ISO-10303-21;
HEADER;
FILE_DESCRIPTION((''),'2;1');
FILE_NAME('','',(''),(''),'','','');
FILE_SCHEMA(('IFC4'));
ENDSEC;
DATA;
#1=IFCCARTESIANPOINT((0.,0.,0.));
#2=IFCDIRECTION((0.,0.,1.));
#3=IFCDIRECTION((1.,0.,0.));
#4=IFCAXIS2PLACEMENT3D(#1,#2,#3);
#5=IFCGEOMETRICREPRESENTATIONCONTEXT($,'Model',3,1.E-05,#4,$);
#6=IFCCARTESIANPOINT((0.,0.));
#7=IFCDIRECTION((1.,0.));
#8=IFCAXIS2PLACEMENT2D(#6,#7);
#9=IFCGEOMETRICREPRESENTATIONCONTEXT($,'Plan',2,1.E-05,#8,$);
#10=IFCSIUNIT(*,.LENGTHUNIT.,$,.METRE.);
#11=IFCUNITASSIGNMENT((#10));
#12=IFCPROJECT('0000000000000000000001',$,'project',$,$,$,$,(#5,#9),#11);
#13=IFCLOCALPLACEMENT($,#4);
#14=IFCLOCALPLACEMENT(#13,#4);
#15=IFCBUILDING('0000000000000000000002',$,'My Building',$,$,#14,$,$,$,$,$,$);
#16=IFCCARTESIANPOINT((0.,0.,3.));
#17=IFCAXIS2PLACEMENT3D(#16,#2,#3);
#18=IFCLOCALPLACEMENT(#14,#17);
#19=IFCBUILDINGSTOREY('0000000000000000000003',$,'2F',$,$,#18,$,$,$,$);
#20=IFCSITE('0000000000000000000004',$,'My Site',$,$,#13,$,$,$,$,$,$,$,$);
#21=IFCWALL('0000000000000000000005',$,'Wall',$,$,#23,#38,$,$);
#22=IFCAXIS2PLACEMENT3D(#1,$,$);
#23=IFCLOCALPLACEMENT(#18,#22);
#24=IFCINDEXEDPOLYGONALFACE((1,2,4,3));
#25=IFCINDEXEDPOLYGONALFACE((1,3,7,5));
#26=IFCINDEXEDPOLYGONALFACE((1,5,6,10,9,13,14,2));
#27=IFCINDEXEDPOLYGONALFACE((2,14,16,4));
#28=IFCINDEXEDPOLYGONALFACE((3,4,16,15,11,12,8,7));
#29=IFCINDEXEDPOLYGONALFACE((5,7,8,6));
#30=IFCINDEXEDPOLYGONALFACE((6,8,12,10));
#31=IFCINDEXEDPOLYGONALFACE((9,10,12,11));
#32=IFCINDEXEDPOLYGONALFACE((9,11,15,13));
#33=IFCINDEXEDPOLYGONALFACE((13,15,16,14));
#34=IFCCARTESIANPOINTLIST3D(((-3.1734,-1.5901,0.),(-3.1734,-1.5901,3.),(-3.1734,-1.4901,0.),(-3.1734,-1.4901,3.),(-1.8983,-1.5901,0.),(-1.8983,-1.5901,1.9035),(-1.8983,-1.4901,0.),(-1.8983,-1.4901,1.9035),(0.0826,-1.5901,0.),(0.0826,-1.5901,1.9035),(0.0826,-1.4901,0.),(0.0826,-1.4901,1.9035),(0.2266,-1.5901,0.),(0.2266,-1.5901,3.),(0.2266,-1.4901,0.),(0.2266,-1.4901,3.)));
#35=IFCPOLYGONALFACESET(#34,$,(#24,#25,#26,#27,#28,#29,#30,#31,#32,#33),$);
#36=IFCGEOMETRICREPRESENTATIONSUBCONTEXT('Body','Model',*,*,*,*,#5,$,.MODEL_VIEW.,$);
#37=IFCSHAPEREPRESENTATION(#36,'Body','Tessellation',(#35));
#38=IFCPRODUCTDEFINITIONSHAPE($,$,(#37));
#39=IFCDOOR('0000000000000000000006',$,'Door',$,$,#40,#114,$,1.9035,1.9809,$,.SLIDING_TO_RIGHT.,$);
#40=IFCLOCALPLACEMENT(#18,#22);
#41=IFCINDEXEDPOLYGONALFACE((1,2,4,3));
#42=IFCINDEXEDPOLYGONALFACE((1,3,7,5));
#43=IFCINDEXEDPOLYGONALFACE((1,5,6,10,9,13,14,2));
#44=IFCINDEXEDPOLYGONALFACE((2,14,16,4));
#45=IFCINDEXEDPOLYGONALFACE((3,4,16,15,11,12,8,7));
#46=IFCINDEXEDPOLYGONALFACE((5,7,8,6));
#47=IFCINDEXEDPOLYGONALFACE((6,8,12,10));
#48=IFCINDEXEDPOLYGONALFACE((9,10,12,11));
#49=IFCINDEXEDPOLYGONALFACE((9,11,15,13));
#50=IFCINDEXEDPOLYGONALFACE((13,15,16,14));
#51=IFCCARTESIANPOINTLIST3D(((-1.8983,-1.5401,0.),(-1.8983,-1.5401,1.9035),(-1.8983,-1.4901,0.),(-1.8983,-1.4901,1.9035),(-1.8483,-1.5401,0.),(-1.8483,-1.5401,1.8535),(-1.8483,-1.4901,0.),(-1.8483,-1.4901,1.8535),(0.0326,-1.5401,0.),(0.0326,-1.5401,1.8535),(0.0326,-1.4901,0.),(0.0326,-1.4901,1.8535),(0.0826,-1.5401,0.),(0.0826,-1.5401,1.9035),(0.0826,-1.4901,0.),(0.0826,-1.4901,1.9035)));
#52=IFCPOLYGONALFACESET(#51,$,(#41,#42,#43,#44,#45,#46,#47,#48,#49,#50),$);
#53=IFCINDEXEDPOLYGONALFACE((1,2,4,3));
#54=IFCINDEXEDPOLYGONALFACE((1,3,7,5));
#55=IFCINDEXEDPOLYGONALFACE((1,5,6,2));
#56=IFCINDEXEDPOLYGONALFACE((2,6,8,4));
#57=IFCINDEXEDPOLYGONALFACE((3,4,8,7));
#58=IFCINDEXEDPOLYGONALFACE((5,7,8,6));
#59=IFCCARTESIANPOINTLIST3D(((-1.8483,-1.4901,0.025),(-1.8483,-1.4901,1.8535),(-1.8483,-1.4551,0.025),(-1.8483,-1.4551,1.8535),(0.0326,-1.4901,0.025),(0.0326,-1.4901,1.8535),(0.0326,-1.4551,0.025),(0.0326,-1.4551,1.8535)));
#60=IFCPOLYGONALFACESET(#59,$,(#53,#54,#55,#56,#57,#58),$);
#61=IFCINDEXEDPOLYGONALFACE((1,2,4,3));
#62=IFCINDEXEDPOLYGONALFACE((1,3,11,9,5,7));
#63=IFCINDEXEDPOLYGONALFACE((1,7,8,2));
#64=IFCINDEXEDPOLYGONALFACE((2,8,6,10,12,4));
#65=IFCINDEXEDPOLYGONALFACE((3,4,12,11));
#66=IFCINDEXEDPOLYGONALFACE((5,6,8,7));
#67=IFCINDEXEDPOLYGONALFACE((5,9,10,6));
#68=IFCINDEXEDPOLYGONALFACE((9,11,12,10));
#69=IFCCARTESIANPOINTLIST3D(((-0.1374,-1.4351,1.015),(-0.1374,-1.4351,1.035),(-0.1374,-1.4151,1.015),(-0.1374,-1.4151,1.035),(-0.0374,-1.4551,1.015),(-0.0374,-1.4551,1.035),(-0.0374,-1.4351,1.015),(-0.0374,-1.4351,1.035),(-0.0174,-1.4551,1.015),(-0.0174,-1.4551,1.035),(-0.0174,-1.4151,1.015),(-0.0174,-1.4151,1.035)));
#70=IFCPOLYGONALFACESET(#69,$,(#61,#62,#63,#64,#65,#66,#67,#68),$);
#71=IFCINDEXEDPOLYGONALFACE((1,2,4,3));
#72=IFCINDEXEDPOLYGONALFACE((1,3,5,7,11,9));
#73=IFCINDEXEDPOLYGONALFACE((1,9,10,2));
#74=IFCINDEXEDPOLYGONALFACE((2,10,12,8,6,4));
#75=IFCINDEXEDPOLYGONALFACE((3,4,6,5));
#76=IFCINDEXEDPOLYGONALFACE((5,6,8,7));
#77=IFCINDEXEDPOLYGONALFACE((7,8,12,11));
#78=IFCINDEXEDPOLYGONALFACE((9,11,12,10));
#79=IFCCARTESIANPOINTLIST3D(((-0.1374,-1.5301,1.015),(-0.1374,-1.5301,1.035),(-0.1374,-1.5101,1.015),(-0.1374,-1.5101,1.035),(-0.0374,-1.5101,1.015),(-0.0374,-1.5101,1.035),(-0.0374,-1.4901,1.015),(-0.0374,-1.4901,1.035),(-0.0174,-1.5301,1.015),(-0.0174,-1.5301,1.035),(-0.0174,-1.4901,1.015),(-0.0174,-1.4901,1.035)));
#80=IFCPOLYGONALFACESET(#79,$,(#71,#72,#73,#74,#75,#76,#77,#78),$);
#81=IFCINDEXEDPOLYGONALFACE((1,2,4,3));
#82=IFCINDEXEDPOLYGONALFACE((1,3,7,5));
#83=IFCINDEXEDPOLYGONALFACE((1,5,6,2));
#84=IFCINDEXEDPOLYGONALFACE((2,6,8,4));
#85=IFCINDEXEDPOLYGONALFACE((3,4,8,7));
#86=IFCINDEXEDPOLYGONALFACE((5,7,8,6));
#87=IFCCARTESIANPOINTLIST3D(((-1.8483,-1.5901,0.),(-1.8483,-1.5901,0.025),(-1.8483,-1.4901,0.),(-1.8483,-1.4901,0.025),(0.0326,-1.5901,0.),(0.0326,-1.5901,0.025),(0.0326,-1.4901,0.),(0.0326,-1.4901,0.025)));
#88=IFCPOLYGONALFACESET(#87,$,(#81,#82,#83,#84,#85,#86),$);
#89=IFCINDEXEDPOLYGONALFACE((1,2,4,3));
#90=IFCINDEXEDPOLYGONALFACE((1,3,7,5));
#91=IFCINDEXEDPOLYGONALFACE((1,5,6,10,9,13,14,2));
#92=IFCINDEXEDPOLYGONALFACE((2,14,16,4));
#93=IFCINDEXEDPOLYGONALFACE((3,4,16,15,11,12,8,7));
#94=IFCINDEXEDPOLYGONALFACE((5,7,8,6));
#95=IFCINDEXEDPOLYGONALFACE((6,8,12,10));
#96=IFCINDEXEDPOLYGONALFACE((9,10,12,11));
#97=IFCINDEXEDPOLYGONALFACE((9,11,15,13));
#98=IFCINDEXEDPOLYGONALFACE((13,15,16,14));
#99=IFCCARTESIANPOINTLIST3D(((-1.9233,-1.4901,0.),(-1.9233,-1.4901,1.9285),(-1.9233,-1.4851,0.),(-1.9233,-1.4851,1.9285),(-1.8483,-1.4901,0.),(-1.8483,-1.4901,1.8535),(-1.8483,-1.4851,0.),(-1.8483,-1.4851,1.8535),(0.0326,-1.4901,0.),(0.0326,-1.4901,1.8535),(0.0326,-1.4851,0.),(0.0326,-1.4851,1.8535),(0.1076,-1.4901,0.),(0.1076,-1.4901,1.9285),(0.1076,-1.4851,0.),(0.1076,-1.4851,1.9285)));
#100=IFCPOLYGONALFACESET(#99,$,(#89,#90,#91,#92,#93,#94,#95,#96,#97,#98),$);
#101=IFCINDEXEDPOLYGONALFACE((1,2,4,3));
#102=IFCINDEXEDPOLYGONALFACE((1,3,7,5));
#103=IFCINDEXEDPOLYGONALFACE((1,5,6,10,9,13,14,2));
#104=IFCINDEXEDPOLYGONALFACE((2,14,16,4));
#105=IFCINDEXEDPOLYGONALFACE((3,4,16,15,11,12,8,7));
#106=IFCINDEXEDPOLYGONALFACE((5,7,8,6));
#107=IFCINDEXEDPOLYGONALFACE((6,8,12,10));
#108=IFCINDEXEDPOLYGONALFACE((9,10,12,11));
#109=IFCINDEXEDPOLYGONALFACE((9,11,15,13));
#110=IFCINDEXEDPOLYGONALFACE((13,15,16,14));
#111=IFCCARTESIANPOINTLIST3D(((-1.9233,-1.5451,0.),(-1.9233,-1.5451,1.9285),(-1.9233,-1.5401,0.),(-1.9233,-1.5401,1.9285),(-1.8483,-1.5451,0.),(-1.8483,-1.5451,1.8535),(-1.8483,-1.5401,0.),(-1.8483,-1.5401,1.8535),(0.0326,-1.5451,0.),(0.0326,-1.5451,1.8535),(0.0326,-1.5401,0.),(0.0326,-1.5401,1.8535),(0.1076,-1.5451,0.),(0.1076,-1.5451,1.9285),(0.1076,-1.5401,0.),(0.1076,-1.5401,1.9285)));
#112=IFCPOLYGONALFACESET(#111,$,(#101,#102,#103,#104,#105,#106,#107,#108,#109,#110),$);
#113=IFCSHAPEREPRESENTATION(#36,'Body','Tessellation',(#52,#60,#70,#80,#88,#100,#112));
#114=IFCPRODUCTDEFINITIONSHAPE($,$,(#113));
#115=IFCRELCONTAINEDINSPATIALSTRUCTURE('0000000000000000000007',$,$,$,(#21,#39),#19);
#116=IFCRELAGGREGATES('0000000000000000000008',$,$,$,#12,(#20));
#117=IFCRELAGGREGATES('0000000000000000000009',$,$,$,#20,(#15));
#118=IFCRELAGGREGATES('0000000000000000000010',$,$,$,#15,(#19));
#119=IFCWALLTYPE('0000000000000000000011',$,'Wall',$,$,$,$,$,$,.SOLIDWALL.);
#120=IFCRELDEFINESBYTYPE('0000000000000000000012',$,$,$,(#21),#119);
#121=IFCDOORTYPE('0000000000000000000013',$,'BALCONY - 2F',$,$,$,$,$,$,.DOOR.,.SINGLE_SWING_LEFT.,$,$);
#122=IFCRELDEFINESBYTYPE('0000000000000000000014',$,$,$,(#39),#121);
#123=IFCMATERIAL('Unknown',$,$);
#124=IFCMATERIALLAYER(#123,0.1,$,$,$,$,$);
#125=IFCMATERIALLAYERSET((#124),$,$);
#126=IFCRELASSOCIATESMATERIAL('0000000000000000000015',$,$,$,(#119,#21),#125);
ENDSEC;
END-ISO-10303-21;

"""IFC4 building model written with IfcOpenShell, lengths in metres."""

from ifc_helpers import new_model, entity, si_unit, frame, origin_with_axes, origin_2d_with_axis, place, context, subcontext, project, spatial, line, indexed_curve, outline, extrude, shape, source, transform, mapped, material, layer, layer_set, layer_usage, type_object, type_shapes, element, fill, save


model = new_model("IFC4")

# Units and contexts
model_context = context("Model", 3, precision=1e-05, world=origin_with_axes())
plan_context = context("Plan", 2, precision=1e-05, world=origin_2d_with_axis())
body_context_1 = subcontext(model_context, "Body", "Model", "MODEL_VIEW")
body_context_2 = subcontext(plan_context, "Body", "Plan", "PLAN_VIEW")
ifc_project = project(units=[si_unit("LENGTHUNIT", "METRE")], contexts=[model_context, plan_context])

# Site, building, storey
site_placement = place(None, origin_with_axes())
site = spatial("IfcSite", under=ifc_project, at=site_placement, Name="My Site")
building_placement = place(site_placement, origin_with_axes())
building = spatial("IfcBuilding", under=site, at=building_placement, Name="My Building")
storey_placement = place(building_placement, frame((0.0, 0.0, 3.0), z_axis=(0.0, 0.0, 1.0), x_axis=(1.0, 0.0, 0.0)))
storey = spatial("IfcBuildingStorey", under=building, at=storey_placement, Name="2F")

# Shared definitions
ifc_material = material(Name="Unknown")

# Shared definitions
ifc_layer_1 = layer(ifc_material, 0.1)
ifc_layer_set_1 = layer_set([ifc_layer_1])
wall_type = type_object("IfcWallType", Name="Wall", PredefinedType="SOLIDWALL", material=ifc_layer_set_1)

# Wall, opening, door
ifc_layer_usage_1 = layer_usage(ifc_layer_set_1, "AXIS2", "POSITIVE", 0.0)
wall_1_placement = place(storey_placement, frame((-3.1734, -1.5901, 0.0), z_axis=(0.0, 0.0, 1.0), x_axis=(1.0, 0.0, 0.0)))
wall_1 = element("IfcWall", 1, at=wall_1_placement, inside=storey, type_object=wall_type, material=ifc_layer_usage_1, Name="Wall", context=body_context_1, shape_type="SweptSolid", body=[
    extrude(outline(indexed_curve([(0.0, 0.0), (0.0, 0.1), (3.4, 0.1), (3.4, 0.0)], segments=[line(1, 2, 3, 4, 1)])), origin_with_axes(), (0.0, 0.0, 1.0), 3.0),
])
shared_shape_1 = source(origin_with_axes(), body_context_1, "Body", "SweptSolid", [
    extrude(outline(indexed_curve([(0.0, 0.0), (1.9809, 0.0), (1.9809, 1.9035), (0.0, 1.9035)], segments=[line(1, 2, 3, 4, 1)])), frame((0.0, -0.6, 0.0), z_axis=(0.0, -1.0, 0.0), x_axis=(1.0, 0.0, 0.0)), (0.0, 0.0, -1.0), 1.2),
])
opening_1_placement = place(wall_1_placement, frame((3.256, 0.1, 0.0), z_axis=(0.0, 0.0, 1.0), x_axis=(-1.0, 0.0, 0.0)))
opening_1 = element("IfcOpeningElement", 2, at=opening_1_placement, cuts=wall_1, PredefinedType="OPENING", context=body_context_1, shape_type="MappedRepresentation", body=[
    mapped(shared_shape_1, transform((0.0, 0.0, 0.0), x_axis=(1.0, 0.0, 0.0), y_axis=(0.0, 1.0, 0.0), z_axis=(0.0, 0.0, 1.0), scale=1.0)),
])
door_type_1 = type_object("IfcDoorType", Name="BALCONY - 2F", OperationType="SINGLE_SWING_LEFT", PredefinedType="DOOR")
shared_shape_2 = source(origin_with_axes(), body_context_1, "Body", "SweptSolid", [
    extrude(outline(indexed_curve([(0.0, 0.0), (0.0, 1.9035), (1.9809, 1.9035), (1.9809, 0.0), (1.9309, 0.0), (1.9309, 1.8535), (0.05, 1.8535), (0.05, 0.0)], segments=[line(1, 2, 3, 4, 5, 6, 7, 8, 1)])), frame((0.0, 0.0, 0.0), z_axis=(0.0, -1.0, 0.0), x_axis=(1.0, 0.0, 0.0)), (0.0, 0.0, -1.0), 0.05),
    extrude(outline(indexed_curve([(0.0, 0.0), (1.8809, 0.0), (1.8809, 0.035), (0.0, 0.035)], segments=[line(1, 2, 3, 4, 1)])), frame((0.05, -0.035, 0.025), z_axis=(0.0, 0.0, 1.0), x_axis=(1.0, 0.0, 0.0)), (0.0, 0.0, 1.0), 1.8285),
    extrude(outline(indexed_curve([(0.0, 0.0), (0.0, -0.04), (0.12, -0.04), (0.12, -0.02), (0.02, -0.02), (0.02, 0.0)], segments=[line(1, 2, 3, 4, 5, 6, 1)])), frame((0.1, -0.035, 1.015), z_axis=(0.0, 0.0, 1.0), x_axis=(1.0, 0.0, 0.0)), (0.0, 0.0, 1.0), 0.02),
    extrude(outline(indexed_curve([(0.0, 0.0), (0.0, 0.04), (0.12, 0.04), (0.12, 0.02), (0.02, 0.02), (0.02, 0.0)], segments=[line(1, 2, 3, 4, 5, 6, 1)])), frame((0.1, 0.0, 1.015), z_axis=(0.0, 0.0, 1.0), x_axis=(1.0, 0.0, 0.0)), (0.0, 0.0, 1.0), 0.02),
    extrude(outline(indexed_curve([(0.0, 0.0), (1.8809, 0.0), (1.8809, 0.1), (0.0, 0.1)], segments=[line(1, 2, 3, 4, 1)])), frame((0.05, 0.0, 0.0), z_axis=(0.0, 0.0, 1.0), x_axis=(1.0, 0.0, 0.0)), (0.0, 0.0, 1.0), 0.025),
    extrude(outline(indexed_curve([(0.0, 0.0), (0.0, 1.9285), (2.0309, 1.9285), (2.0309, 0.0), (1.9559, 0.0), (1.9559, 1.8535), (0.075, 1.8535), (0.075, 0.0)], segments=[line(1, 2, 3, 4, 5, 6, 7, 8, 1)])), frame((-0.025, -0.005, 0.0), z_axis=(0.0, -1.0, 0.0), x_axis=(1.0, 0.0, 0.0)), (0.0, 0.0, -1.0), 0.005),
    extrude(outline(indexed_curve([(0.0, 0.0), (0.0, 1.9285), (2.0309, 1.9285), (2.0309, 0.0), (1.9559, 0.0), (1.9559, 1.8535), (0.075, 1.8535), (0.075, 0.0)], segments=[line(1, 2, 3, 4, 5, 6, 7, 8, 1)])), frame((-0.025, 0.05, 0.0), z_axis=(0.0, -1.0, 0.0), x_axis=(1.0, 0.0, 0.0)), (0.0, 0.0, -1.0), 0.005),
])
shared_shape_3 = source(origin_with_axes(), body_context_2, "Body", "Curve2D", [
    entity("IfcIndexedPolyCurve", entity("IfcCartesianPointList2D", [[0.0, 0.0], [0.05, 0.0], [0.05, 0.05], [0.0, 0.05]]), [entity("IfcLineIndex", [1, 2, 3, 4, 1])]),
    entity("IfcIndexedPolyCurve", entity("IfcCartesianPointList2D", [[1.9809, 0.0], [1.9309, 0.0], [1.9309, 0.05], [1.9809, 0.05]]), [entity("IfcLineIndex", [1, 2, 3, 4, 1])]),
    entity("IfcIndexedPolyCurve", entity("IfcCartesianPointList2D", [[2.8714, -0.035], [0.9905, -0.035], [0.9905, 0.0], [2.8714, 0.0]]), [entity("IfcLineIndex", [1, 2, 3, 4, 1])]),
])
type_shapes(door_type_1, [shared_shape_2, shared_shape_3])
door_1_placement = place(opening_1_placement, frame((0.0, 0.0, 0.0), z_axis=(0.0, 0.0, 1.0), x_axis=(1.0, 0.0, 0.0)))
door_1 = element("IfcDoor", 3, at=door_1_placement, inside=storey, type_object=door_type_1, Name="Door", OperationType="SLIDING_TO_RIGHT", OverallHeight=1.9035, OverallWidth=1.9809, shapes=[
    shape(body_context_1, "Body", "MappedRepresentation", [mapped(shared_shape_2, transform((0.0, 0.0, 0.0), x_axis=(1.0, 0.0, 0.0), y_axis=(0.0, 1.0, 0.0), z_axis=(0.0, 0.0, 1.0), scale=1.0))]),
    shape(body_context_2, "Body", "MappedRepresentation", [mapped(shared_shape_3, transform((0.0, 0.0, 0.0), x_axis=(1.0, 0.0, 0.0), y_axis=(0.0, 1.0, 0.0), z_axis=(0.0, 0.0, 1.0), scale=1.0))]),
])
fill(opening_1, door_1)

save(model, "model.ifc")
